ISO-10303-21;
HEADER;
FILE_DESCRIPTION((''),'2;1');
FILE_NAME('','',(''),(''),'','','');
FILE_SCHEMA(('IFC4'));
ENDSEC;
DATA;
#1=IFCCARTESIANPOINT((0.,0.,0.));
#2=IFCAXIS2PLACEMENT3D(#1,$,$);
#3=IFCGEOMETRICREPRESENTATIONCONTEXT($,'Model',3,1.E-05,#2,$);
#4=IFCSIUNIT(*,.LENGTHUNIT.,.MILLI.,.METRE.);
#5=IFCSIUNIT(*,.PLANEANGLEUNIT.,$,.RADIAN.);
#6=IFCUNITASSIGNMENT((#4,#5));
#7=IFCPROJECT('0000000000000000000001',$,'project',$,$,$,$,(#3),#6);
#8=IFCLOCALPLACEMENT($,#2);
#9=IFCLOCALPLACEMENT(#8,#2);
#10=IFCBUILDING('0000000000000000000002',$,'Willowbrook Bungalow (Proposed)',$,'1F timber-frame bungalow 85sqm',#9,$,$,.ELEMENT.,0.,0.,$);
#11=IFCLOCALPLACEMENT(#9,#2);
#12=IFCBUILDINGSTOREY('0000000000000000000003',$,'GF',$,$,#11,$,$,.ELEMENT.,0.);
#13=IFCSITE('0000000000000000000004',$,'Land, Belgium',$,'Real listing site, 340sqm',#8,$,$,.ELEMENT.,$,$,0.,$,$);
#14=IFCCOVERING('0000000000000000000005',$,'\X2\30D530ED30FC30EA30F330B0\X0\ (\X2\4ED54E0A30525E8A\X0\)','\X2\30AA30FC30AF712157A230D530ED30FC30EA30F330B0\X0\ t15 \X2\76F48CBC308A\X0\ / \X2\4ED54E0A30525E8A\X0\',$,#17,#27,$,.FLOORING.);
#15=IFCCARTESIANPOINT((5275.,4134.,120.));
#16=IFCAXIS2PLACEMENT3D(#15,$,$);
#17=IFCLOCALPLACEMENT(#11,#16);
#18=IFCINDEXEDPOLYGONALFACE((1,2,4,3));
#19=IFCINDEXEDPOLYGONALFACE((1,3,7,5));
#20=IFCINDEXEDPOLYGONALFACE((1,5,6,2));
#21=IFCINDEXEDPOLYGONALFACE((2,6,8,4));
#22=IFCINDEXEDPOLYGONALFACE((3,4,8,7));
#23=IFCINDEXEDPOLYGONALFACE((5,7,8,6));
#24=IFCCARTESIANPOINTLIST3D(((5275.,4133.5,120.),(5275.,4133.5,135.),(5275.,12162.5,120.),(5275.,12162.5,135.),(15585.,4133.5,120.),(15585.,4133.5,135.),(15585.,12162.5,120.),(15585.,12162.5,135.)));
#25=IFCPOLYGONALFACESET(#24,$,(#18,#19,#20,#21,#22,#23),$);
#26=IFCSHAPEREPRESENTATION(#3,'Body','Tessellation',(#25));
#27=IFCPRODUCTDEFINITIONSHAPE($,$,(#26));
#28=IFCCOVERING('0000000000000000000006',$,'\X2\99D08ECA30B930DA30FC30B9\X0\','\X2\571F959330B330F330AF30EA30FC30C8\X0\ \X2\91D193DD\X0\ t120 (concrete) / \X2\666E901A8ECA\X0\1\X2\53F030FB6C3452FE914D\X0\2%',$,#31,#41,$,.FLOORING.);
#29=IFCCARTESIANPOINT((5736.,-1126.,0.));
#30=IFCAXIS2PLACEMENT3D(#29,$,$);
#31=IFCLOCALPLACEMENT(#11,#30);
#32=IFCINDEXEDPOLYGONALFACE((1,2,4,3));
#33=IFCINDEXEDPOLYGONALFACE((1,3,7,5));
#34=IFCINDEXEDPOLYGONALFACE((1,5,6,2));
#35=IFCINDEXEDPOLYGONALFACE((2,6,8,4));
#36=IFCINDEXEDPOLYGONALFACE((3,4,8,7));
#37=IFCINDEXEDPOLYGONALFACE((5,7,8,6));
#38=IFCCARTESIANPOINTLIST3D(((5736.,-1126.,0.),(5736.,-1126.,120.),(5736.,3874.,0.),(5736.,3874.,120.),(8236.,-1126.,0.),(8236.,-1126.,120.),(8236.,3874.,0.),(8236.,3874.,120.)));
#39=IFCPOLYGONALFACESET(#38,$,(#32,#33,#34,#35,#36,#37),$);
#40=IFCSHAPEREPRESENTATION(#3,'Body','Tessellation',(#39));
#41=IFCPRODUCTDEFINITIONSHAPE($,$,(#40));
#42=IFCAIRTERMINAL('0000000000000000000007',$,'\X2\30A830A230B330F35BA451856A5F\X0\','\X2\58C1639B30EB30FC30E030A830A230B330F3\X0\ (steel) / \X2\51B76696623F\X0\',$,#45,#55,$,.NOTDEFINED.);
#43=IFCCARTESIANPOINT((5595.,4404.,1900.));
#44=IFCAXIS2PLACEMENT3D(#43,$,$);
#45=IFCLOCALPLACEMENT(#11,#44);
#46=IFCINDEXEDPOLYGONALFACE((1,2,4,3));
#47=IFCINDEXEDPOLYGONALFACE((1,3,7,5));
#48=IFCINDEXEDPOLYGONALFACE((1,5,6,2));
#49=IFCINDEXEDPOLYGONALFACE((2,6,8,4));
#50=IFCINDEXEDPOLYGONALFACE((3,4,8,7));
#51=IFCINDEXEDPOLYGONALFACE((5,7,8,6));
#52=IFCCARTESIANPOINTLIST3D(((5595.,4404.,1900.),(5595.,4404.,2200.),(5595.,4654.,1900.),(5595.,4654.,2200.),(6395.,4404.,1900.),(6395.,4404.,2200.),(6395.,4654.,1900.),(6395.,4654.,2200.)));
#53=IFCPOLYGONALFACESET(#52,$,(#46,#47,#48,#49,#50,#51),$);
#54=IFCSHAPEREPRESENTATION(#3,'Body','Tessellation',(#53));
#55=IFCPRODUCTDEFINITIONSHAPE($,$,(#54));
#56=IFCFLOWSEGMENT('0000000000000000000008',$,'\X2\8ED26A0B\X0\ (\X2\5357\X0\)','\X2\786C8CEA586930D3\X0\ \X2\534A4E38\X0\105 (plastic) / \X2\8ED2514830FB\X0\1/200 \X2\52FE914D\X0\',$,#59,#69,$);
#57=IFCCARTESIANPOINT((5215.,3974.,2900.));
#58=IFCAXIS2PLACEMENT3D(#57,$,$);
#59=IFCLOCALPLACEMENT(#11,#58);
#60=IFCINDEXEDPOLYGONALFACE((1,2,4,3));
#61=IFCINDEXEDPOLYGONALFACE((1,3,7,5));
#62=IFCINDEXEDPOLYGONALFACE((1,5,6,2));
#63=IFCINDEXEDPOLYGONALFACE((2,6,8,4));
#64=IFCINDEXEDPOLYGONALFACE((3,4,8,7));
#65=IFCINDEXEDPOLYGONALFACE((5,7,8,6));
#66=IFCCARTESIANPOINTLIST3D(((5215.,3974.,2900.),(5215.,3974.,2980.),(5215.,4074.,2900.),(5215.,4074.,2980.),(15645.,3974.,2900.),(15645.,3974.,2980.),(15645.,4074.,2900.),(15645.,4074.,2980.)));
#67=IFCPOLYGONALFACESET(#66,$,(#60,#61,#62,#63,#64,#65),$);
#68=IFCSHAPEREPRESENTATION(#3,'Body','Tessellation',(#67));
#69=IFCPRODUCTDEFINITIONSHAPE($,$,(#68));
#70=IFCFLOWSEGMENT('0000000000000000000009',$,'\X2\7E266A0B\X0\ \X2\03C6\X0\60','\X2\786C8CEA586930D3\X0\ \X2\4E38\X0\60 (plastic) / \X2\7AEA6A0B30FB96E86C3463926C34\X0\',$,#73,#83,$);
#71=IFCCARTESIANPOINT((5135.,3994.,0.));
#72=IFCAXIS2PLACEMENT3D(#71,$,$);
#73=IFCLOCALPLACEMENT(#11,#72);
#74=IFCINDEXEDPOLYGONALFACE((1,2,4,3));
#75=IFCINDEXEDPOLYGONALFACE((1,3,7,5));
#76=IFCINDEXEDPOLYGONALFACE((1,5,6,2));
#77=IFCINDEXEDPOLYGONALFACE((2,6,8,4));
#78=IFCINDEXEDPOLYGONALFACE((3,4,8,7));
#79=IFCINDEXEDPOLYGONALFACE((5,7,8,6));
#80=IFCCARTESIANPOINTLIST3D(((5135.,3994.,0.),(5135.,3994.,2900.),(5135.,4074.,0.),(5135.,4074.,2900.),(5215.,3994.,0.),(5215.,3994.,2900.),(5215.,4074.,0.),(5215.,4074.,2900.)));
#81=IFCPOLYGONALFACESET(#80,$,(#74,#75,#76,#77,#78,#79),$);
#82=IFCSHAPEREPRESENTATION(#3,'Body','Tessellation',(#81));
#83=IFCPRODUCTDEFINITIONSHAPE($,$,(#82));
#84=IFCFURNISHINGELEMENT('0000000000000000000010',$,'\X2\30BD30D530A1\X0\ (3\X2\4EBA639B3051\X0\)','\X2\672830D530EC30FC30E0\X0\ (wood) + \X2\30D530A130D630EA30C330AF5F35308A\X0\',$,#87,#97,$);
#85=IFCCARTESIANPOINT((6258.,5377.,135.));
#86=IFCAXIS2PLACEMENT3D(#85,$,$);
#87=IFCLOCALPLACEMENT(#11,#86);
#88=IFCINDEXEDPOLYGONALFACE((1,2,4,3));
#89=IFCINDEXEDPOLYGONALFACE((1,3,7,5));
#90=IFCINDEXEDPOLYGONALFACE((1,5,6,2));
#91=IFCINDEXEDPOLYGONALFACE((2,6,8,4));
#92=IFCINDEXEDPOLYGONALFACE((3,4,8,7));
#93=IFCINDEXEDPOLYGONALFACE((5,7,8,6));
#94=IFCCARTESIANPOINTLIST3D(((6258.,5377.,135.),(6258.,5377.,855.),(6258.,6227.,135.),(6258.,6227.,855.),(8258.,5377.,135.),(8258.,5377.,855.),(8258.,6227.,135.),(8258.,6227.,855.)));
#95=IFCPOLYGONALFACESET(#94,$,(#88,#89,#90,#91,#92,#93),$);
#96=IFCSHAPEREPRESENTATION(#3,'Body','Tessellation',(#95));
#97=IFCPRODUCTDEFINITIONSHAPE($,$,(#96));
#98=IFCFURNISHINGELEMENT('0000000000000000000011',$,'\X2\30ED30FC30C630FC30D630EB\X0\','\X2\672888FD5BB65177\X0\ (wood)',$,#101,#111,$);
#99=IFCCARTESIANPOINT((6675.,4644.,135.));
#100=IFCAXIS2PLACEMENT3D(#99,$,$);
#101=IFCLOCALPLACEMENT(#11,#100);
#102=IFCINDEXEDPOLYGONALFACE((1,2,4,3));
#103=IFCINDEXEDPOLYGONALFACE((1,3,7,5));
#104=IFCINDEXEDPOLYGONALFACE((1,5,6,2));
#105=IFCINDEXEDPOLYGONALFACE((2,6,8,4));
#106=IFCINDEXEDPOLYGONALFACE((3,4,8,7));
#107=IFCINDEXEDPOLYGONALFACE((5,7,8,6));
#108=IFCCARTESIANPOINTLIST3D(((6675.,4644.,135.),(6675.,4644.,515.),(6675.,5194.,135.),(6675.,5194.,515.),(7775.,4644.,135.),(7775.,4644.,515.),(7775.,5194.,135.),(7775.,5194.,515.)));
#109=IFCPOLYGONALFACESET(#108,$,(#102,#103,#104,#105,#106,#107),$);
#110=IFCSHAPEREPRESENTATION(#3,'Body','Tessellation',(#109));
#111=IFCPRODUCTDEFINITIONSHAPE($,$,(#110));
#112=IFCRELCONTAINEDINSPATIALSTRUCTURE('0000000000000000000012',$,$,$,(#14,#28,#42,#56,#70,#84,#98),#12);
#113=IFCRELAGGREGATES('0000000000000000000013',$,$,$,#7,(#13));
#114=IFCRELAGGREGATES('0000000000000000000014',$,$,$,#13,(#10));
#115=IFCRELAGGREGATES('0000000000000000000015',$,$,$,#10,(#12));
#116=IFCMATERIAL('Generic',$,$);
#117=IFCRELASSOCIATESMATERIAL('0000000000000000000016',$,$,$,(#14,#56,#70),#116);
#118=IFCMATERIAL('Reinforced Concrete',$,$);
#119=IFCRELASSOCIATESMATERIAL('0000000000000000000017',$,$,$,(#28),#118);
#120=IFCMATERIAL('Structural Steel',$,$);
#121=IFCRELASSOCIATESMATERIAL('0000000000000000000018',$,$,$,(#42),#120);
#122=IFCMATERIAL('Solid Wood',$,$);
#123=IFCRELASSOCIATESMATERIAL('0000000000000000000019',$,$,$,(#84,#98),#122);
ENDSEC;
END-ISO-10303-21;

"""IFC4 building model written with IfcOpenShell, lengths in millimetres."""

from ifc_helpers import new_model, si_unit, frame, frame_2d, origin, place, context, project, spatial, rectangle, extrude, material, element, save


model = new_model("IFC4")

# Units and contexts
model_context = context("Model", 3, precision=1e-05, world=origin())
ifc_project = project(units=[si_unit("LENGTHUNIT", "METRE", prefix="MILLI"), si_unit("PLANEANGLEUNIT", "RADIAN")], contexts=[model_context])

# Site, building, storey
site_placement = place(None, origin())
site = spatial("IfcSite", under=ifc_project, at=site_placement, Name="Land, Belgium", ObjectType="Real listing site, 340sqm", CompositionType="ELEMENT", RefElevation=0.0)
building_placement = place(site_placement, origin())
building = spatial("IfcBuilding", under=site, at=building_placement, Name="Willowbrook Bungalow (Proposed)", ObjectType="1F timber-frame bungalow 85sqm", CompositionType="ELEMENT", ElevationOfRefHeight=0.0, ElevationOfTerrain=0.0)
storey_placement = place(building_placement, origin())
storey = spatial("IfcBuildingStorey", under=building, at=storey_placement, Name="GF", CompositionType="ELEMENT", Elevation=0.0)

# Shared definitions
ifc_material_1 = material(Name="Solid Wood")

# Shared definitions
ifc_material_2 = material(Name="Reinforced Concrete")

# Shared definitions
ifc_material_3 = material(Name="Structural Steel")

# Coverings
ifc_material_4 = material(Name="Generic")
covering_1_placement = place(storey_placement, frame((5275.0, 4134.0, 120.0)))
element("IfcCovering", 1, at=covering_1_placement, inside=storey, material=ifc_material_4, Name="フローリング (仕上げ床)", Description="オーク無垢フローリング t15 直貼り / 仕上げ床", PredefinedType="FLOORING", context=model_context, shape_type="SweptSolid", body=[
    extrude(rectangle(XDim=10310.0, YDim=8029.0, at=frame_2d((5155.0, 4014.0))), frame((5275.0, 4134.0, 120.0)), (0.0, 0.0, 1.0), 15.0),
])
covering_2_placement = place(storey_placement, frame((5736.0, -1126.0, 0.0)))
element("IfcCovering", 2, at=covering_2_placement, inside=storey, material=ifc_material_2, Name="駐車スペース", Description="土間コンクリート 金鏝 t120 (concrete) / 普通車1台・水勾配2%", PredefinedType="FLOORING", context=model_context, shape_type="SweptSolid", body=[
    extrude(rectangle(XDim=2500.0, YDim=5000.0, at=frame_2d((1250.0, 2500.0))), frame((5736.0, -1126.0, 0.0)), (0.0, 0.0, 1.0), 120.0),
])

# Air terminal
air_terminal_placement = place(storey_placement, frame((5595.0, 4404.0, 1900.0)))
element("IfcAirTerminal", 3, at=air_terminal_placement, inside=storey, material=ifc_material_3, Name="エアコン室内機", Description="壁掛ルームエアコン (steel) / 冷暖房", PredefinedType="NOTDEFINED", context=model_context, shape_type="SweptSolid", body=[
    extrude(rectangle(XDim=800.0, YDim=250.0, at=frame_2d((400.0, 125.0))), frame((5595.0, 4404.0, 1900.0)), (0.0, 0.0, 1.0), 300.0),
])

# Flow segments
flow_segment_1_placement = place(storey_placement, frame((5215.0, 3974.0, 2900.0)))
element("IfcFlowSegment", 4, at=flow_segment_1_placement, inside=storey, material=ifc_material_4, Name="軒樋 (南)", Description="硬質塩ビ 半丸105 (plastic) / 軒先・1/200 勾配", context=model_context, shape_type="SweptSolid", body=[
    extrude(rectangle(XDim=10430.0, YDim=100.0, at=frame_2d((5215.0, 50.0))), frame((5215.0, 3974.0, 2900.0)), (0.0, 0.0, 1.0), 80.0),
])
flow_segment_2_placement = place(storey_placement, frame((5135.0, 3994.0, 0.0)))
element("IfcFlowSegment", 5, at=flow_segment_2_placement, inside=storey, material=ifc_material_4, Name="縦樋 φ60", Description="硬質塩ビ 丸60 (plastic) / 竪樋・雨水排水", context=model_context, shape_type="SweptSolid", body=[
    extrude(rectangle(XDim=80.0, YDim=80.0, at=frame_2d((40.0, 40.0))), frame((5135.0, 3994.0, 0.0)), (0.0, 0.0, 1.0), 2900.0),
])

# Furnishing elements
furnishing_1_placement = place(storey_placement, frame((6258.0, 5377.0, 135.0)))
element("IfcFurnishingElement", 6, at=furnishing_1_placement, inside=storey, material=ifc_material_1, Name="ソファ (3人掛け)", Description="木フレーム (wood) + ファブリック張り", context=model_context, shape_type="SweptSolid", body=[
    extrude(rectangle(XDim=2000.0, YDim=850.0, at=frame_2d((1000.0, 425.0))), frame((6258.0, 5377.0, 135.0)), (0.0, 0.0, 1.0), 720.0),
])
furnishing_2_placement = place(storey_placement, frame((6675.0, 4644.0, 135.0)))
element("IfcFurnishingElement", 7, at=furnishing_2_placement, inside=storey, material=ifc_material_1, Name="ローテーブル", Description="木製家具 (wood)", context=model_context, shape_type="SweptSolid", body=[
    extrude(rectangle(XDim=1100.0, YDim=550.0, at=frame_2d((550.0, 275.0))), frame((6675.0, 4644.0, 135.0)), (0.0, 0.0, 1.0), 380.0),
])

save(model, "model.ifc")
